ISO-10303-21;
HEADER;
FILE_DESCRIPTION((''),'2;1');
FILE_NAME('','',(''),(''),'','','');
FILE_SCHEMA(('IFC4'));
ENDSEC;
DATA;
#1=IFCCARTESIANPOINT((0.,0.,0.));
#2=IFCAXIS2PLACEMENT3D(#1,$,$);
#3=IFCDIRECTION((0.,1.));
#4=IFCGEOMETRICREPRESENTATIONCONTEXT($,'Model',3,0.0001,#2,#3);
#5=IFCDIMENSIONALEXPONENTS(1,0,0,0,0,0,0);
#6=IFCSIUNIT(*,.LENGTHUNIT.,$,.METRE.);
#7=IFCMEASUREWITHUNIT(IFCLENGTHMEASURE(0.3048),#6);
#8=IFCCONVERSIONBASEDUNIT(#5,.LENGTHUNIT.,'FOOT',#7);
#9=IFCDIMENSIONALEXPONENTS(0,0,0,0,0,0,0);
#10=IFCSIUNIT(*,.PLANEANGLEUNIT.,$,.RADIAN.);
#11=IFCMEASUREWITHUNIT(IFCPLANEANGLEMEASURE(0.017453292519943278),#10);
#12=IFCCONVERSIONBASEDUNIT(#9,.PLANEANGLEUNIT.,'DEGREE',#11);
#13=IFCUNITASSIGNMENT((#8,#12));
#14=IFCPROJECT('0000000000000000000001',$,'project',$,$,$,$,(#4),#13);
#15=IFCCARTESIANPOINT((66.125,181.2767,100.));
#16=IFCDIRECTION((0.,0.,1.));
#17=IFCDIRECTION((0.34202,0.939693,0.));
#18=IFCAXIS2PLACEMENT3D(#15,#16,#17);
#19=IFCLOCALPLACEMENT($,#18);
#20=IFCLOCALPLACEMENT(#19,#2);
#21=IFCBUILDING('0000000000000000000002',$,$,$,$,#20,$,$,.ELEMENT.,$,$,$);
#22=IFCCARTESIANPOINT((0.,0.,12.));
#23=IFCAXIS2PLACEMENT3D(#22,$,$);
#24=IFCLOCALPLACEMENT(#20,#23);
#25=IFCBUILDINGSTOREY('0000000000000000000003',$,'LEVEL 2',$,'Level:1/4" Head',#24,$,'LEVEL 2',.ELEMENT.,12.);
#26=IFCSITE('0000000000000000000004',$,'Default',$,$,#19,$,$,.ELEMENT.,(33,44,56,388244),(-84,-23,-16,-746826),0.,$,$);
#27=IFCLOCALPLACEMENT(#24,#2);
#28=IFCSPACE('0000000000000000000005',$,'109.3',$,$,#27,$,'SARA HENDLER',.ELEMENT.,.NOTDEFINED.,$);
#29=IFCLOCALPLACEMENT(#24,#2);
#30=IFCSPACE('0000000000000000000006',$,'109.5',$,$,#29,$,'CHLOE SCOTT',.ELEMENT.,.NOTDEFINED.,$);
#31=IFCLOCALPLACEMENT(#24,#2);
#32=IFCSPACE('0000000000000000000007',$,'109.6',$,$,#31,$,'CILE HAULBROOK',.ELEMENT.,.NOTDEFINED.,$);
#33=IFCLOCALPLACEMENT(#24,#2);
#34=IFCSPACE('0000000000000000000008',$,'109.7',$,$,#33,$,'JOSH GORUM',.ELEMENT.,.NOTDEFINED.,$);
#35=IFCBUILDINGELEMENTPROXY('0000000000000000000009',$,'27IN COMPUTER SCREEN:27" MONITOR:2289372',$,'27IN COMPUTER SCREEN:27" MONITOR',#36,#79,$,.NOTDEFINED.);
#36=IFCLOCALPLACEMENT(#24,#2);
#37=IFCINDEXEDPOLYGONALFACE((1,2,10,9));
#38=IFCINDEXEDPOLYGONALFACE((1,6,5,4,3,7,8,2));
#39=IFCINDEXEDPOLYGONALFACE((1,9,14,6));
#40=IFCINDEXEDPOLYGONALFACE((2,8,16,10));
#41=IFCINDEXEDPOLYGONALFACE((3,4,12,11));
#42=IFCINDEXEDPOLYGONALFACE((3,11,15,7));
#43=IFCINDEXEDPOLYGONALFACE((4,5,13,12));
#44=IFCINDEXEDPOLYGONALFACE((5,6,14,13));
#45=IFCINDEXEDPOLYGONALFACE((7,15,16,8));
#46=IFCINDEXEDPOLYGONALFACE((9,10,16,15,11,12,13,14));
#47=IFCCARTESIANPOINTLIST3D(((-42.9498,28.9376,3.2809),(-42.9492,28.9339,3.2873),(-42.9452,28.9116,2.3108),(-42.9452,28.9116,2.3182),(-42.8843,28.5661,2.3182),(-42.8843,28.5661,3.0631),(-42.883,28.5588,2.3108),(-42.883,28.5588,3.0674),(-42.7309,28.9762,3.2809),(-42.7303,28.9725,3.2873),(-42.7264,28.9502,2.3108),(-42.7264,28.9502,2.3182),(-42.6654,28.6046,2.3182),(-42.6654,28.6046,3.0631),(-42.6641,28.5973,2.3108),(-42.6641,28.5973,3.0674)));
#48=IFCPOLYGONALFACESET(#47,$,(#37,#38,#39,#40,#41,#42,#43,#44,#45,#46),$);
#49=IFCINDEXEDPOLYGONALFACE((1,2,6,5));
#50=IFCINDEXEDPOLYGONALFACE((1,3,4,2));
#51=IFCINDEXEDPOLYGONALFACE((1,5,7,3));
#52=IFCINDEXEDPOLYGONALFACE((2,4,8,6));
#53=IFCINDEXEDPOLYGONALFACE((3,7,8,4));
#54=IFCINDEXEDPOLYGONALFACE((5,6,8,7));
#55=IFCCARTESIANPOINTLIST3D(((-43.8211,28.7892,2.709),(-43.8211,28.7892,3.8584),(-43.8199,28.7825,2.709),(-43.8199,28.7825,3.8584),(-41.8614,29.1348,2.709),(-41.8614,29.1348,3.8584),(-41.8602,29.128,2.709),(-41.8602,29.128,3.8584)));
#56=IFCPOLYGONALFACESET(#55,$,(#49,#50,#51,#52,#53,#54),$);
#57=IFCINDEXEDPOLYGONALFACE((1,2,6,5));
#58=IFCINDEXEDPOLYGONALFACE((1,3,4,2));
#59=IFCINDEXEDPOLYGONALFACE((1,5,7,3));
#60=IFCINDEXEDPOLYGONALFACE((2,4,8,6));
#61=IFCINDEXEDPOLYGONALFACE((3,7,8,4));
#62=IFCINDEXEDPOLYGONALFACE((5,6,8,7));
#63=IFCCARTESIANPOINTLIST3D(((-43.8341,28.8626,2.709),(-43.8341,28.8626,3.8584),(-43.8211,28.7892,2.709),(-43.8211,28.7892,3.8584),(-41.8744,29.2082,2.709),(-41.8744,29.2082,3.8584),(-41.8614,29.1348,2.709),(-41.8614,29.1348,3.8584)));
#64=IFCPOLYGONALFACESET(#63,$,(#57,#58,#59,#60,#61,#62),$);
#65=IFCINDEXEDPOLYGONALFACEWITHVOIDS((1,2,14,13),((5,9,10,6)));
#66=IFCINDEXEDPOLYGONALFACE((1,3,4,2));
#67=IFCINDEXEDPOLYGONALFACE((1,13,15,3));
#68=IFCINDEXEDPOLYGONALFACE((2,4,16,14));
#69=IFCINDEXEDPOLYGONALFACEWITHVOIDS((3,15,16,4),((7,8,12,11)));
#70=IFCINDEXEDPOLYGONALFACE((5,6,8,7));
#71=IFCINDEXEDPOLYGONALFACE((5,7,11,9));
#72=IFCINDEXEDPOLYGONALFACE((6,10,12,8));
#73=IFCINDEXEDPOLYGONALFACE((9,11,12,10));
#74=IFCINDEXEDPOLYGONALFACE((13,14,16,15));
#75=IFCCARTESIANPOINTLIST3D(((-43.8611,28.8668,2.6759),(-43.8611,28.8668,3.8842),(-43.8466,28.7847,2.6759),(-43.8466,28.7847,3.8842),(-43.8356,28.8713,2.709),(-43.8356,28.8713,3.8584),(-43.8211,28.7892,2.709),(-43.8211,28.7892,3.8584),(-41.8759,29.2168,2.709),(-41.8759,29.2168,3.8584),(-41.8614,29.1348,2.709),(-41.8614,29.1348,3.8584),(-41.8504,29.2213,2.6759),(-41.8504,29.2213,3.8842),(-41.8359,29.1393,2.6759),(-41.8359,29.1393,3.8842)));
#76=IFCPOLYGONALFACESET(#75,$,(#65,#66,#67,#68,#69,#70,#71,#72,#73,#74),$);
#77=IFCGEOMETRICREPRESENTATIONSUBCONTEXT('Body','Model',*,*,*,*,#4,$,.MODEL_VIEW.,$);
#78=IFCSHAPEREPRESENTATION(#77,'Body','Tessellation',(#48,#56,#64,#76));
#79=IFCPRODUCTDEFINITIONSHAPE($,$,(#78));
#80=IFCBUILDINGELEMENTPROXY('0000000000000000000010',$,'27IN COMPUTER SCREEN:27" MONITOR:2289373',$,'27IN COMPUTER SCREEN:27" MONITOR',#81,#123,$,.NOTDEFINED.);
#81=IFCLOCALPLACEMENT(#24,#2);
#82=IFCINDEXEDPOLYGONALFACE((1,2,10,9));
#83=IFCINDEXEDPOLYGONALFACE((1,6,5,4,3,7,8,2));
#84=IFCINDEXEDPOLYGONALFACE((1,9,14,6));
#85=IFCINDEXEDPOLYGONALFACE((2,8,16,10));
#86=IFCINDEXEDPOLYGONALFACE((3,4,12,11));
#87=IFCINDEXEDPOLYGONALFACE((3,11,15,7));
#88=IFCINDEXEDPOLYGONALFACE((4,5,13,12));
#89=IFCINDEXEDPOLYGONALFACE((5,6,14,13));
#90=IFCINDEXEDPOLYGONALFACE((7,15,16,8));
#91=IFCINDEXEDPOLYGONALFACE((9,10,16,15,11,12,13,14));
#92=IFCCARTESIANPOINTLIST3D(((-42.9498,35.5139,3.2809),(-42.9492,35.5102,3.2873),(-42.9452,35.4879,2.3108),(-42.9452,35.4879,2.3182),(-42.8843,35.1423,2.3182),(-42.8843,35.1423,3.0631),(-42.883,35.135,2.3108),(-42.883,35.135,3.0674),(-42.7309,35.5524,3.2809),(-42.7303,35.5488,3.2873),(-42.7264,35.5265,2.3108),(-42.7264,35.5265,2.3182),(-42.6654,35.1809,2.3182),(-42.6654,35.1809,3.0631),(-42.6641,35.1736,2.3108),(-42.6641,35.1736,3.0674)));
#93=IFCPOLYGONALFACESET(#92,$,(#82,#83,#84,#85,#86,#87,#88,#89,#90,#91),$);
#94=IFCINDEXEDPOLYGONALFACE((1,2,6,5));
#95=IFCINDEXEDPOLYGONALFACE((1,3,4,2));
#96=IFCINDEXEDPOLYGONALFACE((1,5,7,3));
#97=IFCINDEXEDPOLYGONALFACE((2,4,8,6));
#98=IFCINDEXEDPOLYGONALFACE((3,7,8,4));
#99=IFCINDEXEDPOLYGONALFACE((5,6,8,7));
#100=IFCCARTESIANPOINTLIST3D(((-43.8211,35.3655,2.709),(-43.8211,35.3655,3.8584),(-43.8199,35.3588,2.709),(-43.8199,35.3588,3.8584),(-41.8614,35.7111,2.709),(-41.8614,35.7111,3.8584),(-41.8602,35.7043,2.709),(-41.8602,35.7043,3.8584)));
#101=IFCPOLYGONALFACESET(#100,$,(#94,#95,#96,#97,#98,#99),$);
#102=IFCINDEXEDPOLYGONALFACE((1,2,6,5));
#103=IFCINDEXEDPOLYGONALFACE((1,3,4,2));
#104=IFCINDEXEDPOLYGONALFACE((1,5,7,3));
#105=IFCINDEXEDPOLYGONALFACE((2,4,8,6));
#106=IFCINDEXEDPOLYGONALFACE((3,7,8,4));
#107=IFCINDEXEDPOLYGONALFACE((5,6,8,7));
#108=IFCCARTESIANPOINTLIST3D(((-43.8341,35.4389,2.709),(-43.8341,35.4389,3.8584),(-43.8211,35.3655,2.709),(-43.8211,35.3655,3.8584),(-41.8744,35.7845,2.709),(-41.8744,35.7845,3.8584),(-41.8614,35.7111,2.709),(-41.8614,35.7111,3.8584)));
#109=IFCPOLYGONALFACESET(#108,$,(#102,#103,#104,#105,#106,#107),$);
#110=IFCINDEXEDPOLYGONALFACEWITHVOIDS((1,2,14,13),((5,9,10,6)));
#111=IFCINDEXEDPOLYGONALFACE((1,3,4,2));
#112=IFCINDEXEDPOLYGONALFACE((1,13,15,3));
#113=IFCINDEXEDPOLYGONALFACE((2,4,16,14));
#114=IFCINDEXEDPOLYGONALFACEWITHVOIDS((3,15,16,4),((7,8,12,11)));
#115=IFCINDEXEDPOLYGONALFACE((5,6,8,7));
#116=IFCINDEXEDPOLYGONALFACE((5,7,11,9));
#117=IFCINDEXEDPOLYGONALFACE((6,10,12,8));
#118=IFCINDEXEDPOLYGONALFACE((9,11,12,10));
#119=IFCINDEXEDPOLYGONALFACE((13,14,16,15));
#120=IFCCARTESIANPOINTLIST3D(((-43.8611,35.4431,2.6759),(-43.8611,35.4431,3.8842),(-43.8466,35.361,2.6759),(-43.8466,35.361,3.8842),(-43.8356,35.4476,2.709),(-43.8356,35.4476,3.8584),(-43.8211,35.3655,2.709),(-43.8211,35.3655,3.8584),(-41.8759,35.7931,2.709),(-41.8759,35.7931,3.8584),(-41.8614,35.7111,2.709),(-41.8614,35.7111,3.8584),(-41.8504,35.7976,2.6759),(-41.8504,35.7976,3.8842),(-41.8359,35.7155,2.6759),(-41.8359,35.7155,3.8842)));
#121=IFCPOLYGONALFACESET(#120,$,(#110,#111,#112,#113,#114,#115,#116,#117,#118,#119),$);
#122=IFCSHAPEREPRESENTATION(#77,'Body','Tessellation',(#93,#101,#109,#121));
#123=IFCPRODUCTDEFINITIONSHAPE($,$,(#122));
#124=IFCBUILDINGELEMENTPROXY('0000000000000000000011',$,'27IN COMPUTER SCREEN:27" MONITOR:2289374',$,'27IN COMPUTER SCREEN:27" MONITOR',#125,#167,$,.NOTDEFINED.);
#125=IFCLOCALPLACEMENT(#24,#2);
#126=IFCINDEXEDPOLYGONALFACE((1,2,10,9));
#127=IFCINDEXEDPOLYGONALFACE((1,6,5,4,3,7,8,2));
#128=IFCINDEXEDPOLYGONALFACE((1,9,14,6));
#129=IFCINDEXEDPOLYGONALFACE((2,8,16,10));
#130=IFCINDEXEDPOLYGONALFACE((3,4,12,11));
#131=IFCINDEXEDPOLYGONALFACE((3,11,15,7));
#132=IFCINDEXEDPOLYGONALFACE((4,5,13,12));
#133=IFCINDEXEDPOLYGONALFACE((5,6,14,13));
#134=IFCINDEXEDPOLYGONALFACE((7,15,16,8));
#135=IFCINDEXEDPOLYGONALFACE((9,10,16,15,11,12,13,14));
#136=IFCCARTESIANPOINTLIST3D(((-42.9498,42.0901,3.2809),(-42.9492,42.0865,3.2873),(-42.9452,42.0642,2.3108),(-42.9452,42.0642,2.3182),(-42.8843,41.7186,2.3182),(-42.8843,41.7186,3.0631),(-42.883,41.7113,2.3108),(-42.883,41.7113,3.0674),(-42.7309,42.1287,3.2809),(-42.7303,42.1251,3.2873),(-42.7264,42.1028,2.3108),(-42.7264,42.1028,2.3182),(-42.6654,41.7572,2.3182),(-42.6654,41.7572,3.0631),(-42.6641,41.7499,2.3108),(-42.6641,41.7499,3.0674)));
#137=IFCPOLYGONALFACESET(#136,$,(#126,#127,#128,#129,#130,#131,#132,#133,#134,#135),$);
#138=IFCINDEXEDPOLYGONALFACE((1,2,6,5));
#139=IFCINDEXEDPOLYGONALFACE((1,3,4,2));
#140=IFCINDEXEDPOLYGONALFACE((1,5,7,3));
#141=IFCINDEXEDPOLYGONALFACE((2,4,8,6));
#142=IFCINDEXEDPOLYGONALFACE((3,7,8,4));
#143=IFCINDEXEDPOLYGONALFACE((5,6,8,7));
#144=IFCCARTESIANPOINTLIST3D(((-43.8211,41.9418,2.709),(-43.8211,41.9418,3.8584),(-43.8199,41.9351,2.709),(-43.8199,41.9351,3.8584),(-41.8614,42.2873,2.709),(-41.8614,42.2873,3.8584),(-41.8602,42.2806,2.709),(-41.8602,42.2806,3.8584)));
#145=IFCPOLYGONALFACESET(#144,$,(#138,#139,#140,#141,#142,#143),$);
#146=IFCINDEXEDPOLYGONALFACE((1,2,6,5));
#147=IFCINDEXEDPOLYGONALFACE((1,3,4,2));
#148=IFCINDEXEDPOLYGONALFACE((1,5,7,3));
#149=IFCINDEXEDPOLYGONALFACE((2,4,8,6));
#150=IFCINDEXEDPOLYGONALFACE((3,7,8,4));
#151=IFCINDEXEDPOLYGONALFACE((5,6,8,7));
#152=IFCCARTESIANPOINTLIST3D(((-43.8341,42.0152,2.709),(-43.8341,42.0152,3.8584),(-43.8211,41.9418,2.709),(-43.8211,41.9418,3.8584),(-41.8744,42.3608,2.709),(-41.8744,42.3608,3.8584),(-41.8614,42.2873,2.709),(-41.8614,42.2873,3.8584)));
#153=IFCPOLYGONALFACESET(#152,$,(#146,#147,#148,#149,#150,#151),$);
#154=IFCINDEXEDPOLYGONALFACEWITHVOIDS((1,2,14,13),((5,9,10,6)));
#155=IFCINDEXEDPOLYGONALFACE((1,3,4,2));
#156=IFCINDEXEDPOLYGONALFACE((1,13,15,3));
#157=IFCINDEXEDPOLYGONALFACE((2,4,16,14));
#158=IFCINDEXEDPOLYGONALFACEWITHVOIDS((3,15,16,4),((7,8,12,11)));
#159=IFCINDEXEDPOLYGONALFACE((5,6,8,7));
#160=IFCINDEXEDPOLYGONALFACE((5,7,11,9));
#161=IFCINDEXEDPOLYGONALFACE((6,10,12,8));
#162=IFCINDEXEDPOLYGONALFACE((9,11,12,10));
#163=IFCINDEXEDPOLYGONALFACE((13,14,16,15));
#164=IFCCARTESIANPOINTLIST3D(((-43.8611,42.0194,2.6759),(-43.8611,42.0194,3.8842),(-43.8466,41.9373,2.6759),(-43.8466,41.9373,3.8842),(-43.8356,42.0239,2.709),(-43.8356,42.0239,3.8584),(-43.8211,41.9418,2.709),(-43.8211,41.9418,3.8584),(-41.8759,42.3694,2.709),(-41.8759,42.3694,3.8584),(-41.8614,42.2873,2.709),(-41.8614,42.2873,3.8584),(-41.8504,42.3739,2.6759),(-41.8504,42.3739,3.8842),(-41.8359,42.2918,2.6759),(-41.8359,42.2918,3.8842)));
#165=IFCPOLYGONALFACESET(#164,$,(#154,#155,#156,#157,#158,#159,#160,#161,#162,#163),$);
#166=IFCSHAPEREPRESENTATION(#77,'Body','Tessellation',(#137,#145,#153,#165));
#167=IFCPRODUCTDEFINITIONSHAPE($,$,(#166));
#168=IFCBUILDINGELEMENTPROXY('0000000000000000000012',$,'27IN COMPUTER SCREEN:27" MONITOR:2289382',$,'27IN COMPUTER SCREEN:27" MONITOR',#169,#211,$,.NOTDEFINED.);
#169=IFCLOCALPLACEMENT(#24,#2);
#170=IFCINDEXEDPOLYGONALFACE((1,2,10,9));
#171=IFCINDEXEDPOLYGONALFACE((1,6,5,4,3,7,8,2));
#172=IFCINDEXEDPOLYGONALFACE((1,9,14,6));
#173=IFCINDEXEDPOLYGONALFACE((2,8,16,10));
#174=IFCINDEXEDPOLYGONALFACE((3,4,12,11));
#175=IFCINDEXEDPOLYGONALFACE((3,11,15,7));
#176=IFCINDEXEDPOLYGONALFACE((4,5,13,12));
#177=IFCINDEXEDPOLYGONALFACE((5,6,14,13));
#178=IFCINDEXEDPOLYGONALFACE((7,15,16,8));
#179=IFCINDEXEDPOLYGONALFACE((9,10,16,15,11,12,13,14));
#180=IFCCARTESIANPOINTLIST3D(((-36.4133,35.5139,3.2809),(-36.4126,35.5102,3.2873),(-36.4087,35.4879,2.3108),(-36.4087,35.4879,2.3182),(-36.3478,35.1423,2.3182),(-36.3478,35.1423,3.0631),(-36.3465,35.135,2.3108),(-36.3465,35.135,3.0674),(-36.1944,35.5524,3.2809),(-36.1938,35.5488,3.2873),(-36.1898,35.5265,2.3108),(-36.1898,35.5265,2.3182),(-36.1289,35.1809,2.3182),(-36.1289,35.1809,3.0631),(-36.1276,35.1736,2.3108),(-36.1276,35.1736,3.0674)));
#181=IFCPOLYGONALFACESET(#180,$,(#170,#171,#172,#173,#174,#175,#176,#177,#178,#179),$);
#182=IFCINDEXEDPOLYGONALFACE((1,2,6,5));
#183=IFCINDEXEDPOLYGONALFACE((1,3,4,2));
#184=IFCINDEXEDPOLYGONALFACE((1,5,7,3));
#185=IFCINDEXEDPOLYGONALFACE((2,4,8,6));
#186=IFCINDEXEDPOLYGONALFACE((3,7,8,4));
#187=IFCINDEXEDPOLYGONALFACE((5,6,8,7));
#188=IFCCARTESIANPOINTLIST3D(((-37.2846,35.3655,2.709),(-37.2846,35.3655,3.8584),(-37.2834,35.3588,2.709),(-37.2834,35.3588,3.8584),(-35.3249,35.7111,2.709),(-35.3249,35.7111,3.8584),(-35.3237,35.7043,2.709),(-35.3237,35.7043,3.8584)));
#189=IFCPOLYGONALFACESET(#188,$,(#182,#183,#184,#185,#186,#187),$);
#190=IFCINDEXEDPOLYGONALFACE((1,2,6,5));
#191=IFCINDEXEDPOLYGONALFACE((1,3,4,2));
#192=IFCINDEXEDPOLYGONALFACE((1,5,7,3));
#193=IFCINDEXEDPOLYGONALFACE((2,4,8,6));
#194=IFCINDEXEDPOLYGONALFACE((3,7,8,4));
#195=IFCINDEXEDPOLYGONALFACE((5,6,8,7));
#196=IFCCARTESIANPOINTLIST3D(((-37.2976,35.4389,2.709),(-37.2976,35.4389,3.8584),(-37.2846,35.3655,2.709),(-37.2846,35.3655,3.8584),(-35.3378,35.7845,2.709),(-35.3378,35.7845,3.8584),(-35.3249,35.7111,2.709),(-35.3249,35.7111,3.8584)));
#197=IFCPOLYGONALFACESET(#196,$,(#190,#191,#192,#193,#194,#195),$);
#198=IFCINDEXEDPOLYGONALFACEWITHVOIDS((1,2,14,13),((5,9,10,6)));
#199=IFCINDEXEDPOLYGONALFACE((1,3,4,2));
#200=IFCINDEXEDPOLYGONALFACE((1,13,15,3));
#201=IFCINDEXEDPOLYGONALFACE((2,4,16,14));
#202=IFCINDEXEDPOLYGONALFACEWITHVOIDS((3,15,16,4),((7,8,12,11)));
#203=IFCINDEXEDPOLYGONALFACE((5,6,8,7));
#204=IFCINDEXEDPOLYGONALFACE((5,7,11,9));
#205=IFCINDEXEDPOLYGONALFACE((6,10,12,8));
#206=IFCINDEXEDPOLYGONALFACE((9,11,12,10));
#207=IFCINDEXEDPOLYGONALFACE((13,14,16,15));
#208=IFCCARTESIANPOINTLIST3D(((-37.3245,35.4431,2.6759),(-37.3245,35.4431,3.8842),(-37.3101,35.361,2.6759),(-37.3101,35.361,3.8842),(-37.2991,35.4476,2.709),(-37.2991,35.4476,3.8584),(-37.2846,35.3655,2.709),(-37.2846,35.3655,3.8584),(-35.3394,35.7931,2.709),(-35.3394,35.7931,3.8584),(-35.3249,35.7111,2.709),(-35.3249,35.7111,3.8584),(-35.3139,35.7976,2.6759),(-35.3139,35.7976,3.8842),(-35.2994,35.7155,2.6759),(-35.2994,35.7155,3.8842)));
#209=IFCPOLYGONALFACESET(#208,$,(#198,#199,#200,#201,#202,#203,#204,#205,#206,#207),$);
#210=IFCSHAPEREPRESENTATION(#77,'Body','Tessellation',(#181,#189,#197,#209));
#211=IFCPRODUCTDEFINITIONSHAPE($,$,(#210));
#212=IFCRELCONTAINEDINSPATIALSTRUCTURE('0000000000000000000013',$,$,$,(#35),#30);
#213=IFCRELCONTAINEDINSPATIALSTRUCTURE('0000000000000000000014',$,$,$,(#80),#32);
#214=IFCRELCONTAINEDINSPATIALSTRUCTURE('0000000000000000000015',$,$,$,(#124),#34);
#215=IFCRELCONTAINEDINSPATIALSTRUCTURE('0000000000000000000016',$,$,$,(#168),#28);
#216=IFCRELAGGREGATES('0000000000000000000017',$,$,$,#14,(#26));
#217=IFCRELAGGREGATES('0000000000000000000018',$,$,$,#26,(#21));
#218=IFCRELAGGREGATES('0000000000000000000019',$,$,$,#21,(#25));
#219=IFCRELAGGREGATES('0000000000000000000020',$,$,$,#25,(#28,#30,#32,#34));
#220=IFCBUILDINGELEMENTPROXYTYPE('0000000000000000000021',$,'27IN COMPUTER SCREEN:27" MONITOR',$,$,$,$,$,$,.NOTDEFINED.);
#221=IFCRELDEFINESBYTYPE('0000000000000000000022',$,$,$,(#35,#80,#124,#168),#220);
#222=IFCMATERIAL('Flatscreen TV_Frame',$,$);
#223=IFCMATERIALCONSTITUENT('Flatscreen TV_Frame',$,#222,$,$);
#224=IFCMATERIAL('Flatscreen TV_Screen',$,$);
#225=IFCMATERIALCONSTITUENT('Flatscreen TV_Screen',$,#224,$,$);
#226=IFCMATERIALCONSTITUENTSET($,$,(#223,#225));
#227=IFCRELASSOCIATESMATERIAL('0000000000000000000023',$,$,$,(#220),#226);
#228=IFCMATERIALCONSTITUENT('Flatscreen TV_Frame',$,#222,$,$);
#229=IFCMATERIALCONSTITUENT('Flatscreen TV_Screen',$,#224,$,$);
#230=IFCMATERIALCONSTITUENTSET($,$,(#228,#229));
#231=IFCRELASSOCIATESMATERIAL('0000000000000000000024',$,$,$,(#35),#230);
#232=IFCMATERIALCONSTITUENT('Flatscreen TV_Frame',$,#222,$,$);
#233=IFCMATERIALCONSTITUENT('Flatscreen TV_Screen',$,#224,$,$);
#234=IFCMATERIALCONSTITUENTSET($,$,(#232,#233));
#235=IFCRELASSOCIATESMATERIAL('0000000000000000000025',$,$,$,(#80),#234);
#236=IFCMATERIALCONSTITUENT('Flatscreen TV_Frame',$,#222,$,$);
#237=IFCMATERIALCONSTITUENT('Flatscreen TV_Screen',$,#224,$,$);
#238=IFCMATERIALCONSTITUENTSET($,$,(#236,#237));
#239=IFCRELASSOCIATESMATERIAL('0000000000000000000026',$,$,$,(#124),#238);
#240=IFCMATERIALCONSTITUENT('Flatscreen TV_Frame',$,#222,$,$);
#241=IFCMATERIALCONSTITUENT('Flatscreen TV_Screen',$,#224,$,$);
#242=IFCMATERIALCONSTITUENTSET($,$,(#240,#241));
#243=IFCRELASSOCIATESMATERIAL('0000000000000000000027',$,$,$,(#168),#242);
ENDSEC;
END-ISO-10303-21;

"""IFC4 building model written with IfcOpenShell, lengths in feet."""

from ifc_helpers import new_model, entity, si_unit, converted_unit, direction, frame, frame_2d, origin, origin_2d_with_axis, place, context, subcontext, project, spatial, polyline, rectangle, outline, extrude, source, transform, mapped, material, constituent, constituent_set, type_object, type_shapes, element, save


model = new_model("IFC4")

# Units and contexts
model_context = context("Model", 3, precision=0.0001, world=origin(), true_north=direction((0.0, 1.0)))
body_context = subcontext(model_context, "Body", "Model", "MODEL_VIEW")
ifc_project = project(units=[converted_unit("LENGTHUNIT", "FOOT", entity("IfcLengthMeasure", 0.3048), si_unit("LENGTHUNIT", "METRE"), dimensions=[1, 0, 0, 0, 0, 0, 0]), converted_unit("PLANEANGLEUNIT", "DEGREE", entity("IfcPlaneAngleMeasure", 0.017453292519943278), si_unit("PLANEANGLEUNIT", "RADIAN"), dimensions=[0, 0, 0, 0, 0, 0, 0])], contexts=[model_context])

# Site, building, storey
site_placement = place(None, frame((66.125, 181.2767, 100.0), z_axis=(0.0, 0.0, 1.0), x_axis=(0.34202, 0.939693, 0.0)))
site = spatial("IfcSite", under=ifc_project, at=site_placement, Name="Default", CompositionType="ELEMENT", RefLatitude=(33, 44, 56, 388244), RefLongitude=(-84, -23, -16, -746826), RefElevation=0.0)
building_placement = place(site_placement, origin())
building = spatial("IfcBuilding", under=site, at=building_placement, CompositionType="ELEMENT")
storey_placement = place(building_placement, frame((0.0, 0.0, 12.0)))
storey = spatial("IfcBuildingStorey", under=building, at=storey_placement, Name="LEVEL 2", ObjectType="Level:1/4\" Head", LongName="LEVEL 2", CompositionType="ELEMENT", Elevation=12.0)

# Shared definitions
space_1_placement = place(storey_placement, origin())
space_1 = spatial("IfcSpace", under=storey, at=space_1_placement, Name="109.3", LongName="SARA HENDLER", CompositionType="ELEMENT", PredefinedType="NOTDEFINED")

# Shared definitions
space_2_placement = place(storey_placement, origin())
space_2 = spatial("IfcSpace", under=storey, at=space_2_placement, Name="109.5", LongName="CHLOE SCOTT", CompositionType="ELEMENT", PredefinedType="NOTDEFINED")

# Shared definitions
space_3_placement = place(storey_placement, origin())
space_3 = spatial("IfcSpace", under=storey, at=space_3_placement, Name="109.6", LongName="CILE HAULBROOK", CompositionType="ELEMENT", PredefinedType="NOTDEFINED")

# Shared definitions
space_4_placement = place(storey_placement, origin())
space_4 = spatial("IfcSpace", under=storey, at=space_4_placement, Name="109.7", LongName="JOSH GORUM", CompositionType="ELEMENT", PredefinedType="NOTDEFINED")

# Building element proxies
ifc_material_1 = material(Name="Flatscreen TV_Frame")
ifc_material_2 = material(Name="Flatscreen TV_Screen")
ifc_constituent_1 = constituent(ifc_material_1, Name="Flatscreen TV_Frame")
ifc_constituent_2 = constituent(ifc_material_2, Name="Flatscreen TV_Screen")
ifc_constituent_set_1 = constituent_set(constituents=[ifc_constituent_1, ifc_constituent_2])
ifc_constituent_3 = constituent(ifc_material_1, Name="Flatscreen TV_Frame")
ifc_constituent_4 = constituent(ifc_material_2, Name="Flatscreen TV_Screen")
ifc_constituent_set_2 = constituent_set(constituents=[ifc_constituent_3, ifc_constituent_4])
building_element_proxy_type_1 = type_object("IfcBuildingElementProxyType", Name="27IN COMPUTER SCREEN:27\" MONITOR", PredefinedType="NOTDEFINED", material=ifc_constituent_set_2)
shared_shape_1 = source(origin(), body_context, "Body", "SweptSolid", [
    extrude(outline(polyline([(0.3657, -0.4392), (0.3731, -0.4392), (0.3731, 0.0007), (-0.2821, 0.379), (-0.4613, 0.0686), (-0.4548, 0.0649), (-0.2794, 0.3688), (0.3657, -0.0036), (0.3657, -0.4392)])), frame((-0.1111, 0.0264, 0.0687), z_axis=(1.0, 0.0, 0.0), x_axis=(0.0, -0.5, 0.866025)), (0.0, 0.0, 1.0), 0.2222),
    extrude(rectangle(XDim=1.9899, YDim=0.0068, at=origin_2d_with_axis()), frame((0.0, 0.2257, 0.0331), z_axis=(0.0, 0.0, 1.0), x_axis=(-1.0, 0.0, 0.0)), (0.0, 0.0, 1.0), 1.1493),
    extrude(rectangle(XDim=1.9899, YDim=0.0746, at=frame_2d((0.0, 0.0), x_axis=(1.0, 0.0))), frame((0.0, 0.2664, 0.0331), z_axis=(0.0, 0.0, 1.0), x_axis=(-1.0, 0.0, 0.0)), (0.0, 0.0, 1.0), 1.1493),
    extrude(outline(polyline([(-0.6042, -1.0208), (0.6042, -1.0208), (0.6042, 1.0208), (-0.6042, 1.0208), (-0.6042, -1.0208)]), holes=[polyline([(-0.5783, -0.995), (-0.5783, 0.995), (0.571, 0.995), (0.571, -0.995), (-0.5783, -0.995)])]), frame((0.0, 0.2292, 0.6042), z_axis=(0.0, 1.0, 0.0), x_axis=(0.0, 0.0, -1.0)), (0.0, 0.0, 1.0), 0.0833),
])
type_shapes(building_element_proxy_type_1, [shared_shape_1])
proxy_1_placement = place(space_2_placement, frame((-42.8015, 28.7363, 2.6759), z_axis=(0.0, 0.0, 1.0), x_axis=(0.984808, 0.173648, 0.0)))
element("IfcBuildingElementProxy", 1, at=proxy_1_placement, inside=space_2, type_object=building_element_proxy_type_1, material=ifc_constituent_set_1, Name="27IN COMPUTER SCREEN:27\" MONITOR:2289372", ObjectType="27IN COMPUTER SCREEN:27\" MONITOR", PredefinedType="NOTDEFINED", context=body_context, shape_type="MappedRepresentation", body=[
    mapped(shared_shape_1, transform((0.0, 0.0, 0.0), scale=1.0)),
])
ifc_constituent_5 = constituent(ifc_material_1, Name="Flatscreen TV_Frame")
ifc_constituent_6 = constituent(ifc_material_2, Name="Flatscreen TV_Screen")
ifc_constituent_set_3 = constituent_set(constituents=[ifc_constituent_5, ifc_constituent_6])
proxy_2_placement = place(space_3_placement, frame((-42.8015, 35.3126, 2.6759), z_axis=(0.0, 0.0, 1.0), x_axis=(0.984808, 0.173648, 0.0)))
element("IfcBuildingElementProxy", 2, at=proxy_2_placement, inside=space_3, type_object=building_element_proxy_type_1, material=ifc_constituent_set_3, Name="27IN COMPUTER SCREEN:27\" MONITOR:2289373", ObjectType="27IN COMPUTER SCREEN:27\" MONITOR", PredefinedType="NOTDEFINED", context=body_context, shape_type="MappedRepresentation", body=[
    mapped(shared_shape_1, transform((0.0, 0.0, 0.0), scale=1.0)),
])
ifc_constituent_7 = constituent(ifc_material_1, Name="Flatscreen TV_Frame")
ifc_constituent_8 = constituent(ifc_material_2, Name="Flatscreen TV_Screen")
ifc_constituent_set_4 = constituent_set(constituents=[ifc_constituent_7, ifc_constituent_8])
proxy_3_placement = place(space_4_placement, frame((-42.8015, 41.8889, 2.6759), z_axis=(0.0, 0.0, 1.0), x_axis=(0.984808, 0.173648, 0.0)))
element("IfcBuildingElementProxy", 3, at=proxy_3_placement, inside=space_4, type_object=building_element_proxy_type_1, material=ifc_constituent_set_4, Name="27IN COMPUTER SCREEN:27\" MONITOR:2289374", ObjectType="27IN COMPUTER SCREEN:27\" MONITOR", PredefinedType="NOTDEFINED", context=body_context, shape_type="MappedRepresentation", body=[
    mapped(shared_shape_1, transform((0.0, 0.0, 0.0), scale=1.0)),
])
ifc_constituent_9 = constituent(ifc_material_1, Name="Flatscreen TV_Frame")
ifc_constituent_10 = constituent(ifc_material_2, Name="Flatscreen TV_Screen")
ifc_constituent_set_5 = constituent_set(constituents=[ifc_constituent_9, ifc_constituent_10])
proxy_4_placement = place(space_1_placement, frame((-36.265, 35.3126, 2.6759), z_axis=(0.0, 0.0, 1.0), x_axis=(0.984808, 0.173648, 0.0)))
element("IfcBuildingElementProxy", 4, at=proxy_4_placement, inside=space_1, type_object=building_element_proxy_type_1, material=ifc_constituent_set_5, Name="27IN COMPUTER SCREEN:27\" MONITOR:2289382", ObjectType="27IN COMPUTER SCREEN:27\" MONITOR", PredefinedType="NOTDEFINED", context=body_context, shape_type="MappedRepresentation", body=[
    mapped(shared_shape_1, transform((0.0, 0.0, 0.0), scale=1.0)),
])

save(model, "model.ifc")
